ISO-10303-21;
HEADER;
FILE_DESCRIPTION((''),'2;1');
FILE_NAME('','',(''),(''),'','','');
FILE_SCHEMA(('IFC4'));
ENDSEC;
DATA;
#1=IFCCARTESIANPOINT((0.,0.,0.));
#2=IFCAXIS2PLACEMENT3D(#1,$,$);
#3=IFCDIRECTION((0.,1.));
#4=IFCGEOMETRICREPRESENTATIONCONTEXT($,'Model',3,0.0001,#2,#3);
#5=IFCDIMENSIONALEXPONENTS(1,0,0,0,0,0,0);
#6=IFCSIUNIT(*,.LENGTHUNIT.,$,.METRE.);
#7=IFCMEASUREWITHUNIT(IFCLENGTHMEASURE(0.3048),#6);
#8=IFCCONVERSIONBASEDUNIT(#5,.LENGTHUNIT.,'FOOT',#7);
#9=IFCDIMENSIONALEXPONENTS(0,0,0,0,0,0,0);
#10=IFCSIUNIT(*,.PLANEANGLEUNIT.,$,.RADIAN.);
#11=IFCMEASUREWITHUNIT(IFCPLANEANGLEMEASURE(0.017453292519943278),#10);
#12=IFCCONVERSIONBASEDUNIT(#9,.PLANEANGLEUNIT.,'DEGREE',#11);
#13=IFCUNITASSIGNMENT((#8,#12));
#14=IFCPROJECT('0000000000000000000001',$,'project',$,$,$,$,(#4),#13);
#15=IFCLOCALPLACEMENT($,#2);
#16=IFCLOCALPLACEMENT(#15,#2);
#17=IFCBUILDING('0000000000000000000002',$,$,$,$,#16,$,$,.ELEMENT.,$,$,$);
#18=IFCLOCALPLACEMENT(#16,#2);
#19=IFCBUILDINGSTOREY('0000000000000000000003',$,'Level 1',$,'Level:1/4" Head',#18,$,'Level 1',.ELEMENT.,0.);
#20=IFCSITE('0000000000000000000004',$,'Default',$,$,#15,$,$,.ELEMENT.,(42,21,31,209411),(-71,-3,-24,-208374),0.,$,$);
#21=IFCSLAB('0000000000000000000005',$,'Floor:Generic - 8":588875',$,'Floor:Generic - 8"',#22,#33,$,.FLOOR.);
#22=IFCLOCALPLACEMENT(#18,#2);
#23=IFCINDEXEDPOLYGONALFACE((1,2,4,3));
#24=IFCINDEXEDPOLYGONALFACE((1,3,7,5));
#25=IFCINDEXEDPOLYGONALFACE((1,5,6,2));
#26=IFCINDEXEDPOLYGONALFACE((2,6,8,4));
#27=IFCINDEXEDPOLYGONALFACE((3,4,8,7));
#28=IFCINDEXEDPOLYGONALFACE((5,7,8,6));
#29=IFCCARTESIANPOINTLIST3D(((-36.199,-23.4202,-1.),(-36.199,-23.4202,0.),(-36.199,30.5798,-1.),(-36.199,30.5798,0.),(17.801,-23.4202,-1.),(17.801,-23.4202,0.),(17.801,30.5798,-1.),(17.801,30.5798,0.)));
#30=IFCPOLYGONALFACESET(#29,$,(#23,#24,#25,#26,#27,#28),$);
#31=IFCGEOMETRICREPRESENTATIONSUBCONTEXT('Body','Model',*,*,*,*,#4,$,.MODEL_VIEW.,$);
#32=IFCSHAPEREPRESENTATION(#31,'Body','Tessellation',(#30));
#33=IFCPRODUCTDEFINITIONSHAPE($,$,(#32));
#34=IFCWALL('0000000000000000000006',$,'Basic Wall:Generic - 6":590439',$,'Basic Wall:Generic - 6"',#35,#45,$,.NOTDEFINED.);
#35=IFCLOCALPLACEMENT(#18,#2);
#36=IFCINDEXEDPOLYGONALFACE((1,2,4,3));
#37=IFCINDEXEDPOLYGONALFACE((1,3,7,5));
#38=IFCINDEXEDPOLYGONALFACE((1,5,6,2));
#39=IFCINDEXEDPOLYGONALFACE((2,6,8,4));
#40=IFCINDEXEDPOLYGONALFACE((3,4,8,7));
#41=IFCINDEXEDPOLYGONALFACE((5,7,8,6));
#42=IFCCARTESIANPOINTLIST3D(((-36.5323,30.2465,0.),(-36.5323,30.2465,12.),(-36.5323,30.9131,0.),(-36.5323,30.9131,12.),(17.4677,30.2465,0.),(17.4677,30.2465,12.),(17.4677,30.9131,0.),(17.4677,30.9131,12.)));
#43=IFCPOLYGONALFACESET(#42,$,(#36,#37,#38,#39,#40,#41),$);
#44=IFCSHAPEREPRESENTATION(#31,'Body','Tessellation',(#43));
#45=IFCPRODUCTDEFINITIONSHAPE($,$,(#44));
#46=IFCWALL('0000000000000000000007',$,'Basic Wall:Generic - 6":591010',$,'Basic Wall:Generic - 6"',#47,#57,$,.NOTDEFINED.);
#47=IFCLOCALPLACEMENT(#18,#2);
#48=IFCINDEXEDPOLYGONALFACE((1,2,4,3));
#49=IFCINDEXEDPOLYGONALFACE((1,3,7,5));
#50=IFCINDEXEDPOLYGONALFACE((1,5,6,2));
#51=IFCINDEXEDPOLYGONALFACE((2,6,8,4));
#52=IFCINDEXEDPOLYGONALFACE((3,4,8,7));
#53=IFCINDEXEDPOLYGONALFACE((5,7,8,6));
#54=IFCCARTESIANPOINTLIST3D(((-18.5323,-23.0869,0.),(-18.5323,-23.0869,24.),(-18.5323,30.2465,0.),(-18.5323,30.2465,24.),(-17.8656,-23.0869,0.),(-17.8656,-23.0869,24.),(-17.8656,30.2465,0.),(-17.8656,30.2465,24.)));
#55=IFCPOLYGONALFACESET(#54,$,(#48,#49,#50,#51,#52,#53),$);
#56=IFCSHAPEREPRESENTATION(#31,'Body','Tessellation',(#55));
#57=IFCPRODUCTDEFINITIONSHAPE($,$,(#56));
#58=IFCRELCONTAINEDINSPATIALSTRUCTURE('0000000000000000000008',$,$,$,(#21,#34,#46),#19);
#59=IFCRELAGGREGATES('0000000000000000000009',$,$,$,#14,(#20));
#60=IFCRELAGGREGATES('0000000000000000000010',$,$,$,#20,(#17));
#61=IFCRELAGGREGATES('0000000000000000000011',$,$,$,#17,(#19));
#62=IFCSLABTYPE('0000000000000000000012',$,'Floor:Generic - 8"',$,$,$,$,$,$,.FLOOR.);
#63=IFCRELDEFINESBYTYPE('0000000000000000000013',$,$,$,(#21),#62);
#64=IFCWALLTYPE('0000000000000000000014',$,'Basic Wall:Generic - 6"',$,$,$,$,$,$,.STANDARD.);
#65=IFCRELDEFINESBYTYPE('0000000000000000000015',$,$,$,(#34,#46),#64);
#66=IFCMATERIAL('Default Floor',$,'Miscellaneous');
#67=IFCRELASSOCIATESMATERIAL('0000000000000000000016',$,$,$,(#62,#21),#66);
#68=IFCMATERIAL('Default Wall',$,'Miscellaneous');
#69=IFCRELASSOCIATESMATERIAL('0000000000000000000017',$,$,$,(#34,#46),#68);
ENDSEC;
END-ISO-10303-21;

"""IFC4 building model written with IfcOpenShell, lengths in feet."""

from ifc_helpers import new_model, entity, si_unit, converted_unit, direction, frame, origin, place, context, subcontext, project, spatial, indexed_curve, outline, extrude, material, type_object, element, save


model = new_model("IFC4")

# Units and contexts
model_context = context("Model", 3, precision=0.0001, world=origin(), true_north=direction((0.0, 1.0)))
body_context = subcontext(model_context, "Body", "Model", "MODEL_VIEW")
ifc_project = project(units=[converted_unit("LENGTHUNIT", "FOOT", entity("IfcLengthMeasure", 0.3048), si_unit("LENGTHUNIT", "METRE"), dimensions=[1, 0, 0, 0, 0, 0, 0]), converted_unit("PLANEANGLEUNIT", "DEGREE", entity("IfcPlaneAngleMeasure", 0.017453292519943278), si_unit("PLANEANGLEUNIT", "RADIAN"), dimensions=[0, 0, 0, 0, 0, 0, 0])], contexts=[model_context])

# Site, building, storey
site_placement = place(None, origin())
site = spatial("IfcSite", under=ifc_project, at=site_placement, Name="Default", CompositionType="ELEMENT", RefLatitude=(42, 21, 31, 209411), RefLongitude=(-71, -3, -24, -208374), RefElevation=0.0)
building_placement = place(site_placement, origin())
building = spatial("IfcBuilding", under=site, at=building_placement, CompositionType="ELEMENT")
storey_placement = place(building_placement, origin())
storey = spatial("IfcBuildingStorey", under=building, at=storey_placement, Name="Level 1", ObjectType="Level:1/4\" Head", LongName="Level 1", CompositionType="ELEMENT", Elevation=0.0)

# Slab
ifc_material_1 = material(Name="Default Floor", Category="Miscellaneous")
slab_type = type_object("IfcSlabType", Name="Floor:Generic - 8\"", PredefinedType="FLOOR", material=ifc_material_1)
slab_placement = place(storey_placement, origin())
element("IfcSlab", 1, at=slab_placement, inside=storey, type_object=slab_type, material=ifc_material_1, Name="Floor:Generic - 8\":588875", ObjectType="Floor:Generic - 8\"", PredefinedType="FLOOR", context=body_context, shape_type="SweptSolid", body=[
    extrude(outline(indexed_curve([(-27.0, -27.0), (27.0, -27.0), (27.0, 27.0), (-27.0, 27.0), (-27.0, -27.0)], self_intersect=False)), frame((-9.199, 3.5798, 0.0), z_axis=(0.0, 0.0, -1.0), x_axis=(0.0, 1.0, 0.0)), (0.0, 0.0, 1.0), 1.0),
])

# Walls
ifc_material_2 = material(Name="Default Wall", Category="Miscellaneous")
wall_type = type_object("IfcWallType", Name="Basic Wall:Generic - 6\"", PredefinedType="STANDARD")
wall_1_placement = place(storey_placement, frame((-36.5323, 30.5798, 0.0)))
element("IfcWall", 2, at=wall_1_placement, inside=storey, type_object=wall_type, material=ifc_material_2, Name="Basic Wall:Generic - 6\":590439", ObjectType="Basic Wall:Generic - 6\"", PredefinedType="NOTDEFINED", context=body_context, shape_type="SweptSolid", body=[
    extrude(outline(indexed_curve([(54.0, 0.3333), (0.0, 0.3333), (0.0, -0.3333), (54.0, -0.3333), (54.0, 0.3333)], self_intersect=False)), origin(), (0.0, 0.0, 1.0), 12.0),
])
wall_2_placement = place(storey_placement, frame((-18.199, 30.2465, 0.0), z_axis=(0.0, 0.0, 1.0), x_axis=(0.0, -1.0, 0.0)))
element("IfcWall", 3, at=wall_2_placement, inside=storey, type_object=wall_type, material=ifc_material_2, Name="Basic Wall:Generic - 6\":591010", ObjectType="Basic Wall:Generic - 6\"", PredefinedType="NOTDEFINED", context=body_context, shape_type="SweptSolid", body=[
    extrude(outline(indexed_curve([(53.3333, 0.3333), (0.0, 0.3333), (0.0, -0.3333), (53.3333, -0.3333), (53.3333, 0.3333)], self_intersect=False)), origin(), (0.0, 0.0, 1.0), 24.0),
])

save(model, "model.ifc")
